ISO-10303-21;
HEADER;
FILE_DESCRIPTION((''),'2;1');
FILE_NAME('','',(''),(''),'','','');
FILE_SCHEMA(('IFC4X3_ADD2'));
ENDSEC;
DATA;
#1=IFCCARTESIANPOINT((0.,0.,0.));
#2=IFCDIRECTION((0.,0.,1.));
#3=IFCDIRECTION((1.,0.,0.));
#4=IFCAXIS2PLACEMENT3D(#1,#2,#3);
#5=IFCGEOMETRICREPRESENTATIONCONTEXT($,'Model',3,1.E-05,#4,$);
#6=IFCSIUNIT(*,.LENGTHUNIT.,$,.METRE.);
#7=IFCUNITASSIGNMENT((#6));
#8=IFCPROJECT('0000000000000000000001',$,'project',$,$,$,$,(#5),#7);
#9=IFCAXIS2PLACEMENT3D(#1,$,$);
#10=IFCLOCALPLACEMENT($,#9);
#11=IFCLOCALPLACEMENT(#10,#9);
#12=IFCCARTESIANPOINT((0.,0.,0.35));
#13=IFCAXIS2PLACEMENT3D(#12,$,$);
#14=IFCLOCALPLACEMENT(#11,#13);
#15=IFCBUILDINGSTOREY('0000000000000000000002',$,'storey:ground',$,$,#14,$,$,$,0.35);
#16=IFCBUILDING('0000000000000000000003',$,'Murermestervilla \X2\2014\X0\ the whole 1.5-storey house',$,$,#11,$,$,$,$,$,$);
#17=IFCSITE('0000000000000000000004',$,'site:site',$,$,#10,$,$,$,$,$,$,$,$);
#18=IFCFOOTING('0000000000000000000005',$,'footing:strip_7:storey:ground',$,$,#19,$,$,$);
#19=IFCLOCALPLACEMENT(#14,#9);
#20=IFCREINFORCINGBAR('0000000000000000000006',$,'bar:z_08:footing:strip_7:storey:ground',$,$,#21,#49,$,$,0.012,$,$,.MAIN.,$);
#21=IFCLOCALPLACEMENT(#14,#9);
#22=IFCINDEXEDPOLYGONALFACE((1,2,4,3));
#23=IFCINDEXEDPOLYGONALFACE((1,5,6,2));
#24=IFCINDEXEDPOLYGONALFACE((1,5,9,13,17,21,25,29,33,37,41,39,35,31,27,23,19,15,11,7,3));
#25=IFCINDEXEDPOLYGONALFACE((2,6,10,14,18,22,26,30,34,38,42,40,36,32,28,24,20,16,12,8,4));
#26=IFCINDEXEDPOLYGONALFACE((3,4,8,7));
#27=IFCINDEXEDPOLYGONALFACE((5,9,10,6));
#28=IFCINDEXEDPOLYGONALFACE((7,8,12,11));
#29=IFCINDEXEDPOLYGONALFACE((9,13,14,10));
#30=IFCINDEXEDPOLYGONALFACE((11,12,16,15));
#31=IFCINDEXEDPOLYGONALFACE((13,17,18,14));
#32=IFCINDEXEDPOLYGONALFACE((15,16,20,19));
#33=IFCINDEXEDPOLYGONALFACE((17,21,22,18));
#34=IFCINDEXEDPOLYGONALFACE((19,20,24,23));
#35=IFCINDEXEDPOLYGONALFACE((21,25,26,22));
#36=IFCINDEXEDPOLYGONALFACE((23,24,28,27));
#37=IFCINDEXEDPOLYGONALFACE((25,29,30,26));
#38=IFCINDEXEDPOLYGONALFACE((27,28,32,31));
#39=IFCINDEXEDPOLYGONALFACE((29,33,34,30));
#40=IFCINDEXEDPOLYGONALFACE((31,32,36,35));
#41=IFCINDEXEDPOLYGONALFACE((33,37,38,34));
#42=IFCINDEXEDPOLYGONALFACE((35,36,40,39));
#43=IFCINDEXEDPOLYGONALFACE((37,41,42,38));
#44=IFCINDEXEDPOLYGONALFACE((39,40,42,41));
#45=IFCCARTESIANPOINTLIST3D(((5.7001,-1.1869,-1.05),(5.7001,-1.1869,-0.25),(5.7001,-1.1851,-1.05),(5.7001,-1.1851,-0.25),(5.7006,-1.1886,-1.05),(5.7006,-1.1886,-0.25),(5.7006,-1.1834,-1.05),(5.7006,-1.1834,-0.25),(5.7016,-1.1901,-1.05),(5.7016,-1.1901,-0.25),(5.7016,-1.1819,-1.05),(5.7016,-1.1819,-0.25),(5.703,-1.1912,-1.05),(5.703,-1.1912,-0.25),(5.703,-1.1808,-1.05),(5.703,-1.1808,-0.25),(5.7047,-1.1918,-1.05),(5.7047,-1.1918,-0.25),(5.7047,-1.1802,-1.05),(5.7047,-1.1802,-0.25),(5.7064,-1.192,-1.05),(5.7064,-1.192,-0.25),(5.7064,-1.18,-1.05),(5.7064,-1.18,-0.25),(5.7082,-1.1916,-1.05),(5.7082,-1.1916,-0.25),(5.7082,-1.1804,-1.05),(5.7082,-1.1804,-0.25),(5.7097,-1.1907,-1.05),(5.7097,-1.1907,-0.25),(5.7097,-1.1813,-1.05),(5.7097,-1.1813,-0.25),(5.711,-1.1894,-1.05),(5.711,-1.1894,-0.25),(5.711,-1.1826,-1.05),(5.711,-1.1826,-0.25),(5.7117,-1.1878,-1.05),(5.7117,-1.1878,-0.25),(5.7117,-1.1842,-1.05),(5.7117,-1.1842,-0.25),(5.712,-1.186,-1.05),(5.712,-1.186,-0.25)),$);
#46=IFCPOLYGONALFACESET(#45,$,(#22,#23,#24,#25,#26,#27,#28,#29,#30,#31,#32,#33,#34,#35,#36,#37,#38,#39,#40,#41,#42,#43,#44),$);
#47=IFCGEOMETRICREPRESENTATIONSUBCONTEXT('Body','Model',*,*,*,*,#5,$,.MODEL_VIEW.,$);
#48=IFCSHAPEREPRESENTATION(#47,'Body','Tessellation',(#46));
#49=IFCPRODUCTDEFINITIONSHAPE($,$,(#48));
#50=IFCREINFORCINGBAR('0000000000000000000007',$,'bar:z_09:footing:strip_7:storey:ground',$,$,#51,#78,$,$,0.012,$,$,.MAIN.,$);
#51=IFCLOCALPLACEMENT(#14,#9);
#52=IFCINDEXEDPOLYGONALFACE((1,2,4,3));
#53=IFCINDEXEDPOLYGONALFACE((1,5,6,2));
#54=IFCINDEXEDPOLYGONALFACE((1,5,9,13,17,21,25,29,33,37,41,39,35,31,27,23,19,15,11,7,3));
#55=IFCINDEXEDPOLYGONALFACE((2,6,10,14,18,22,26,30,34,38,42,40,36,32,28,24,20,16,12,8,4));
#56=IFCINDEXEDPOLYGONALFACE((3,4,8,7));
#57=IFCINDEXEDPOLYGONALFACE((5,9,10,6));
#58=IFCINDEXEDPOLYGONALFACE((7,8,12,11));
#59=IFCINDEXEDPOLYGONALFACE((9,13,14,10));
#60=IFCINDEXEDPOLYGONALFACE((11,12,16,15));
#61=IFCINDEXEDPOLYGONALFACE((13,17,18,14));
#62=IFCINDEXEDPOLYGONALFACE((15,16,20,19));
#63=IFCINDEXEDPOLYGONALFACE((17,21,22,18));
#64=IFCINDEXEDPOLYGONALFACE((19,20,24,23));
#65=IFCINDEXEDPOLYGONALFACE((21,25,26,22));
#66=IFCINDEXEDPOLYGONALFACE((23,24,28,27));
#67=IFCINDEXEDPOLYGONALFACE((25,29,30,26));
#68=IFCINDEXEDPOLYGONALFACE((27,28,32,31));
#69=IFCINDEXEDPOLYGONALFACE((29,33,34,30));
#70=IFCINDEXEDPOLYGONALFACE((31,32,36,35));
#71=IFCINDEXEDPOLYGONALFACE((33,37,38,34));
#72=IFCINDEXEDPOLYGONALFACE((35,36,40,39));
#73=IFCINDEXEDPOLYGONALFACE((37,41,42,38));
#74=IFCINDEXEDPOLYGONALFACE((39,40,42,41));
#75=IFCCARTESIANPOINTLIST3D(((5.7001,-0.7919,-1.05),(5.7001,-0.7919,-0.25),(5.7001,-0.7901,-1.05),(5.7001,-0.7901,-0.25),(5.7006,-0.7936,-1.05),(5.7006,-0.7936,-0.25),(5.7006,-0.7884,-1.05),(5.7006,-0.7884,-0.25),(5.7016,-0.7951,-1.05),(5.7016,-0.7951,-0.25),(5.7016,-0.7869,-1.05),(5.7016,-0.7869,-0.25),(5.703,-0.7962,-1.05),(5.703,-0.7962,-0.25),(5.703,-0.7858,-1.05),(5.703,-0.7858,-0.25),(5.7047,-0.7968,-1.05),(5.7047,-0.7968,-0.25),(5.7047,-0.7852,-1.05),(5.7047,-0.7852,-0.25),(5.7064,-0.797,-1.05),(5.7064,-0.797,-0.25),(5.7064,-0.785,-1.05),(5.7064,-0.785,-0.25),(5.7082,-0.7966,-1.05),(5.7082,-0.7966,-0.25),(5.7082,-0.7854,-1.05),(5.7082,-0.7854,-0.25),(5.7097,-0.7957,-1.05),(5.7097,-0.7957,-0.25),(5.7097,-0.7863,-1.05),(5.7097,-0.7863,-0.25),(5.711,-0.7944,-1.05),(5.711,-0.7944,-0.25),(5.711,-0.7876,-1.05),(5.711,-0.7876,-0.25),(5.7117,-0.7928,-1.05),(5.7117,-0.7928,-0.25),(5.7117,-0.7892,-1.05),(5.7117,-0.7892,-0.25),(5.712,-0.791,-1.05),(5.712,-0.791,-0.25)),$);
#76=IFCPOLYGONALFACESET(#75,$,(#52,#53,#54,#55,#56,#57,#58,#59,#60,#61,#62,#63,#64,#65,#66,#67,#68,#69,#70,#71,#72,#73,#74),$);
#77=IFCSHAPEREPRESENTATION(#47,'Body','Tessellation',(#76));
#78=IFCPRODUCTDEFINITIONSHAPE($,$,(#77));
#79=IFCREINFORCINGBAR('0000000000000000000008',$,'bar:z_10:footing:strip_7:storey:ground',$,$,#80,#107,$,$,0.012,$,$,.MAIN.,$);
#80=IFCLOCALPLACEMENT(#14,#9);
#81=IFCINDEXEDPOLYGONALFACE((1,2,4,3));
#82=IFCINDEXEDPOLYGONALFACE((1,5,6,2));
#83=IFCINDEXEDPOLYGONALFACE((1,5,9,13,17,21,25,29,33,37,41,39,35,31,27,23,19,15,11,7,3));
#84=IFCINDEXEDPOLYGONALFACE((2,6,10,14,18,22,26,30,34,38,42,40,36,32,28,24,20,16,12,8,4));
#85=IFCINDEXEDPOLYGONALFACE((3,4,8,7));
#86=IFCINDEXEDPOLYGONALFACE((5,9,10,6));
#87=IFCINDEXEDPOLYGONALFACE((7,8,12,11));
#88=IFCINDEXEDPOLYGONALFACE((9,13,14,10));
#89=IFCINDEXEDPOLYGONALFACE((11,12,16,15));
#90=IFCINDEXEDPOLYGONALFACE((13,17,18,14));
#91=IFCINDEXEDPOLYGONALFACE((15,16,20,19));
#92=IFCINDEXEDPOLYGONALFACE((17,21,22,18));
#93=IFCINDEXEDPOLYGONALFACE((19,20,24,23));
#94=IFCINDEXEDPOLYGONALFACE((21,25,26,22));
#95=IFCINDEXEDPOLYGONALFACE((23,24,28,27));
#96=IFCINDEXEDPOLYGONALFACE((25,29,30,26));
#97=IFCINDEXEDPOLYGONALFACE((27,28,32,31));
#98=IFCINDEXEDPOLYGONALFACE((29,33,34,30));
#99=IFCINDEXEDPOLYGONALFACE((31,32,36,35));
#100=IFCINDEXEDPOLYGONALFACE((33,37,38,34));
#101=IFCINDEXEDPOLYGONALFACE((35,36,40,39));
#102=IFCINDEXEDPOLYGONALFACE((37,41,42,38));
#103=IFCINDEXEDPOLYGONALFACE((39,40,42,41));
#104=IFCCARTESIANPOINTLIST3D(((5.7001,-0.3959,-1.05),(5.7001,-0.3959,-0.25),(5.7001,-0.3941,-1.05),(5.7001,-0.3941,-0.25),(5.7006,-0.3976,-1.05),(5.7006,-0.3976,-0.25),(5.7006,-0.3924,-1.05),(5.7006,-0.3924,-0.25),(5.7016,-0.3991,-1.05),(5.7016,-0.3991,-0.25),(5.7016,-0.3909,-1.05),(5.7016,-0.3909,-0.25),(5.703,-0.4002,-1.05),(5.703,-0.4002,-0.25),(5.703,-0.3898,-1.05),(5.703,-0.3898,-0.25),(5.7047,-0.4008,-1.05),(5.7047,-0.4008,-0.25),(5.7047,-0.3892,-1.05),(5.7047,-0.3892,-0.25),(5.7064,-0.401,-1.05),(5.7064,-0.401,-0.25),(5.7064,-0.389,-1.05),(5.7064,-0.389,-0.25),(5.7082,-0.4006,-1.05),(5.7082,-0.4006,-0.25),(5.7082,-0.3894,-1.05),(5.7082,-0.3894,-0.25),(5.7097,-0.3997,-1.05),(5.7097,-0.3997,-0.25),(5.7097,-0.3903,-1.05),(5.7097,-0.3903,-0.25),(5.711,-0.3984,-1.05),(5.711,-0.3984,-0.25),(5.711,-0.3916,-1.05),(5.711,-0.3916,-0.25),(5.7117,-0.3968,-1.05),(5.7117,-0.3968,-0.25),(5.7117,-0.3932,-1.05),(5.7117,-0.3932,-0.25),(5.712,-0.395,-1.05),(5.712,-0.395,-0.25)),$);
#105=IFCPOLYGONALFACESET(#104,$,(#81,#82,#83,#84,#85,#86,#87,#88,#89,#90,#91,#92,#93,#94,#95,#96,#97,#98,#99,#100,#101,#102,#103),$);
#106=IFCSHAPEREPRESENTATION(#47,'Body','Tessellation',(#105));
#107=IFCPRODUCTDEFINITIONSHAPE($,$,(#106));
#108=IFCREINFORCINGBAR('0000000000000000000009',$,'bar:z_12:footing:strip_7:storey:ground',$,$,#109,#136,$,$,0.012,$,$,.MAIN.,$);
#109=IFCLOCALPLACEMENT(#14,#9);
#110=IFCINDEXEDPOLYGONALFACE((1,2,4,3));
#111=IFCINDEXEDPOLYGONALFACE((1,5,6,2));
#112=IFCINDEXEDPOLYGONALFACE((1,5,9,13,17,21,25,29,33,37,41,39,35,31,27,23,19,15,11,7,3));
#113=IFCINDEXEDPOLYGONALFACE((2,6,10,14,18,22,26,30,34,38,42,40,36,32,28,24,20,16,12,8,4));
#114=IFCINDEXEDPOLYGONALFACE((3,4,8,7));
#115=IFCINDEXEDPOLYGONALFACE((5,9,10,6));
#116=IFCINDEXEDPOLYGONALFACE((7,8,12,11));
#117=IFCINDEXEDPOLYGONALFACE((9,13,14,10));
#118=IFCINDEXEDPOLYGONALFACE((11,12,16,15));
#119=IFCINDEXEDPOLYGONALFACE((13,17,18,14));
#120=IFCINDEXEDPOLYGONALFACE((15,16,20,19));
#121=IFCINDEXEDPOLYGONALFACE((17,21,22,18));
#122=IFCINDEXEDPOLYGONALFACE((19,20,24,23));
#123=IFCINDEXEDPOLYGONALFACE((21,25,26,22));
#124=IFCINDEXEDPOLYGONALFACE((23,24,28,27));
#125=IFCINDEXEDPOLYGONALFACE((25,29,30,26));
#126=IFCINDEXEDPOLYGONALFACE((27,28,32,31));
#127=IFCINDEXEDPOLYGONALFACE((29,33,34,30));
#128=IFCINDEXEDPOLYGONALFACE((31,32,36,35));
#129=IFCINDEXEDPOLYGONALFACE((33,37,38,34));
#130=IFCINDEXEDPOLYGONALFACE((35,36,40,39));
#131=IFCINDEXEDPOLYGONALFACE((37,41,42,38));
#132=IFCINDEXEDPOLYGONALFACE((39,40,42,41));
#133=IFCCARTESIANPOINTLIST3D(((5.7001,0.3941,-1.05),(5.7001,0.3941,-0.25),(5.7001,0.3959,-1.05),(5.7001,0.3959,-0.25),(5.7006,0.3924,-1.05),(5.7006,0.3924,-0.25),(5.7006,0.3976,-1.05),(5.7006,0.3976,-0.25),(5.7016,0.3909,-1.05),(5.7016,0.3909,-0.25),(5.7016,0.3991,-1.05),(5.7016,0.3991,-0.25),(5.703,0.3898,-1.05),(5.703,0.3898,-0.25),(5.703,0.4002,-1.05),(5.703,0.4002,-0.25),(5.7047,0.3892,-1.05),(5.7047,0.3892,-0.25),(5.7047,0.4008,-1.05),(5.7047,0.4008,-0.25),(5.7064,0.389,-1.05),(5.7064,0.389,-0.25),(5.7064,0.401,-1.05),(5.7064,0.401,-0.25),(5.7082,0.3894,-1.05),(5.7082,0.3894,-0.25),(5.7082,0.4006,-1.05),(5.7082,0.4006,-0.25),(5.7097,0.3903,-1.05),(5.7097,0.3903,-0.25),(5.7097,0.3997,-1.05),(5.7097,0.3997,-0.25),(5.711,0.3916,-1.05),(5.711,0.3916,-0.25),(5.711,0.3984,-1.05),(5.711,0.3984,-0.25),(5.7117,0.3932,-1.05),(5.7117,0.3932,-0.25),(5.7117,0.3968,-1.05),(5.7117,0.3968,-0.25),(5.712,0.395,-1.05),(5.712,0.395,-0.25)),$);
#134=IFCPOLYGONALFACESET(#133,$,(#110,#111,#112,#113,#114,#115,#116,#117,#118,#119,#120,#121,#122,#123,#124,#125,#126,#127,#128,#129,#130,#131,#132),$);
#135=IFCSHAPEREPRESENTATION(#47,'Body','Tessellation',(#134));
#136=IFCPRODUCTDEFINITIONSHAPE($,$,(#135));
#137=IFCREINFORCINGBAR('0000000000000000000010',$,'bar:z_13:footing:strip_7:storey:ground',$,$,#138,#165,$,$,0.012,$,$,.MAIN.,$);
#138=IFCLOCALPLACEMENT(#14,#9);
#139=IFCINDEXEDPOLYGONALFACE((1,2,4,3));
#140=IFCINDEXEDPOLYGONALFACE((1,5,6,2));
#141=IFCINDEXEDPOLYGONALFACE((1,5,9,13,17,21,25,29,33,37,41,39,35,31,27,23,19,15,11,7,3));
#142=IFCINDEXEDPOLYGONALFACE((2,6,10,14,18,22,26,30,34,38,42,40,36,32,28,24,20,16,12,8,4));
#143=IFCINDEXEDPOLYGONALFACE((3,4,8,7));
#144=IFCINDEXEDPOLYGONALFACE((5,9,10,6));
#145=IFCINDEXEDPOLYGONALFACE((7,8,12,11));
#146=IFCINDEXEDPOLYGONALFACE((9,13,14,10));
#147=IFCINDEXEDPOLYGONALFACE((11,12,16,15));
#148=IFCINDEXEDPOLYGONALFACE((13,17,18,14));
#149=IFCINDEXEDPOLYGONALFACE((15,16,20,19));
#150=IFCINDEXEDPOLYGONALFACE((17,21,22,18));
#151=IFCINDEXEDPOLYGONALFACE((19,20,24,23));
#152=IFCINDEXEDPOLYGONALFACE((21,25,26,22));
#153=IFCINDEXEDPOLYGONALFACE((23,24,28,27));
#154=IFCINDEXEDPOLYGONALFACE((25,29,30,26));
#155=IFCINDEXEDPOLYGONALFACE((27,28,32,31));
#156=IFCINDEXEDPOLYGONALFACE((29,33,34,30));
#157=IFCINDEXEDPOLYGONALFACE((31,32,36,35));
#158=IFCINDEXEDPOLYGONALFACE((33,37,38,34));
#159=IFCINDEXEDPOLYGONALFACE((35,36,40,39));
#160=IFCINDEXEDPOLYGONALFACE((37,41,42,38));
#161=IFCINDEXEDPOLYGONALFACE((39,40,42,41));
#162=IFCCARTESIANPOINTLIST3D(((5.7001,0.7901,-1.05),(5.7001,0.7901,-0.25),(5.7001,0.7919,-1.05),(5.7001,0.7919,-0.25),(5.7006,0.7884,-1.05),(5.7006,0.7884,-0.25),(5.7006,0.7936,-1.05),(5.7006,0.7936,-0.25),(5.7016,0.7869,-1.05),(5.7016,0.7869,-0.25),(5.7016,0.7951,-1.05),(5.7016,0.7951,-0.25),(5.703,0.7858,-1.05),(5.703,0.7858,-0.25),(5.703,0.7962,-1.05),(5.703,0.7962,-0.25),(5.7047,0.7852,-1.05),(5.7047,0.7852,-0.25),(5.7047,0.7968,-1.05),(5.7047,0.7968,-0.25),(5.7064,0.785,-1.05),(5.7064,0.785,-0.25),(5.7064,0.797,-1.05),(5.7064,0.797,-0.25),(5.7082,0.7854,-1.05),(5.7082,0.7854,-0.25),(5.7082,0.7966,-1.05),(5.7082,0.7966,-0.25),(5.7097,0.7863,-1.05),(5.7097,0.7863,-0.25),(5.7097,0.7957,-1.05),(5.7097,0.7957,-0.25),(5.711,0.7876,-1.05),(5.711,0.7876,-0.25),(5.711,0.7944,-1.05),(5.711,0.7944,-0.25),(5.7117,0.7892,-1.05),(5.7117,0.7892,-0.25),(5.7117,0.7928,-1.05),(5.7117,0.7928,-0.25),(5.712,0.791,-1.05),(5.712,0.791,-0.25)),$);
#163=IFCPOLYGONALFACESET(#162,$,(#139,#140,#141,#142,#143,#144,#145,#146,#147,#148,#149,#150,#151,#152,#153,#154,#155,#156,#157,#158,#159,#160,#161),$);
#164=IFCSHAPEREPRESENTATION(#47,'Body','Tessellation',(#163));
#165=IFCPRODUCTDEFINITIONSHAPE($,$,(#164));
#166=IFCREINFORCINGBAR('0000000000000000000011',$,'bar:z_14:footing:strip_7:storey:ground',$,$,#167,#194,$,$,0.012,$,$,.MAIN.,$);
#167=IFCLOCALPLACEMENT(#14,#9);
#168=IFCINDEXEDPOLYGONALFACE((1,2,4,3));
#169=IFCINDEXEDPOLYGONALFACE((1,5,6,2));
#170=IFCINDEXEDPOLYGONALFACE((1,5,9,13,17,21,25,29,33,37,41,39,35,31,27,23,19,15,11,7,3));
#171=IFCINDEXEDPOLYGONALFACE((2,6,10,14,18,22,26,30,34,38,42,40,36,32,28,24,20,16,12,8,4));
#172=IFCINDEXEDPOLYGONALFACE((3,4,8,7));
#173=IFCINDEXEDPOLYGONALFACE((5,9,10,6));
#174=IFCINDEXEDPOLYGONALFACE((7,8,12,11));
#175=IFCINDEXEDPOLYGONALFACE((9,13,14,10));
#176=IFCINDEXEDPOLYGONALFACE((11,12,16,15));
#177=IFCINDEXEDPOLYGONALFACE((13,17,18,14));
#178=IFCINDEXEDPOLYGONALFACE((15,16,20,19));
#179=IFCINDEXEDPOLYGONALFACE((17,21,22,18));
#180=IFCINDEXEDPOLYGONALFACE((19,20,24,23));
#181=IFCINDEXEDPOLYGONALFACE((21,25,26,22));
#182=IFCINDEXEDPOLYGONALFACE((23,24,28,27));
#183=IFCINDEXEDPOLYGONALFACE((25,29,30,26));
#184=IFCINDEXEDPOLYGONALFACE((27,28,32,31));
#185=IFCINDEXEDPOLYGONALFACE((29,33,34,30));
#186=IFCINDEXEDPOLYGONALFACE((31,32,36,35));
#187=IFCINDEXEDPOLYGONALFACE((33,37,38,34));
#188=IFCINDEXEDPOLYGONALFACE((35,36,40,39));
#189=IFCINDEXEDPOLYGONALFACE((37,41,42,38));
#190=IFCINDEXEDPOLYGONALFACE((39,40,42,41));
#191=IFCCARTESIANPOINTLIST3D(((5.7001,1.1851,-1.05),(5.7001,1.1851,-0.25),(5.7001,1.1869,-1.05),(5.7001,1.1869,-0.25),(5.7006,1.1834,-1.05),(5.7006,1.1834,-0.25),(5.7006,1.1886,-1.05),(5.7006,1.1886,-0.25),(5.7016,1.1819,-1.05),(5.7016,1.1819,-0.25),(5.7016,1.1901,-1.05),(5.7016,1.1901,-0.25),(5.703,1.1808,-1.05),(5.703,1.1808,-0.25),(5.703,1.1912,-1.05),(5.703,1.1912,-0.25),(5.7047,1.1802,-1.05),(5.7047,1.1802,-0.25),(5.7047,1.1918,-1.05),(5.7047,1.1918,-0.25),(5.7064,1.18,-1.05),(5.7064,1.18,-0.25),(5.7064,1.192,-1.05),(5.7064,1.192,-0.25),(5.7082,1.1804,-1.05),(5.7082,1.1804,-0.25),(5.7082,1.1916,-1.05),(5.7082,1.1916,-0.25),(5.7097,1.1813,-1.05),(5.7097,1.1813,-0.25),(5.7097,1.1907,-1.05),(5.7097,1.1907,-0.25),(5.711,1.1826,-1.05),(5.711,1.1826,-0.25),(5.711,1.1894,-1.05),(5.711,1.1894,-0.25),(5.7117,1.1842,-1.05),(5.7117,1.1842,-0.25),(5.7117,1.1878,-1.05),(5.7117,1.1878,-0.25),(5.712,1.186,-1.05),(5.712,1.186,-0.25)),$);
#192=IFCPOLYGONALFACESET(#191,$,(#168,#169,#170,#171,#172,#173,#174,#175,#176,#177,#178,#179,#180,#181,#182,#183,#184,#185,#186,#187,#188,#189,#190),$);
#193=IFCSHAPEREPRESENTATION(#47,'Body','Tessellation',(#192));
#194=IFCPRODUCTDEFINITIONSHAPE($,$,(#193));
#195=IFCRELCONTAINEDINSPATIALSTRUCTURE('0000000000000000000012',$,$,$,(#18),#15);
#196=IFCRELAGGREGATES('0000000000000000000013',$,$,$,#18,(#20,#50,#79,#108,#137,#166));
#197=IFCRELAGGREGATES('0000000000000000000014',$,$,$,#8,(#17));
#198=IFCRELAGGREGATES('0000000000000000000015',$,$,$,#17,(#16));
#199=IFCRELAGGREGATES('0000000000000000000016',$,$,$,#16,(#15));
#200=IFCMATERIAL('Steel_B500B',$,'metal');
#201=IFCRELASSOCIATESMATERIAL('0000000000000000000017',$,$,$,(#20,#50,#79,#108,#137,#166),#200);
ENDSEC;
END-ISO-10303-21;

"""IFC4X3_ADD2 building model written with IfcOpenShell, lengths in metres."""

from ifc_helpers import new_model, entity, si_unit, frame, origin, origin_with_axes, place, context, subcontext, project, spatial, material, element, aggregate, save


model = new_model("IFC4X3_ADD2")

# Units and contexts
model_context = context("Model", 3, precision=1e-05, world=origin_with_axes())
body_context = subcontext(model_context, "Body", "Model", "MODEL_VIEW")
ifc_project = project(units=[si_unit("LENGTHUNIT", "METRE")], contexts=[model_context])

# Site, building, storey
placement_1 = place(None, origin())
site = spatial("IfcSite", under=ifc_project, at=placement_1, Name="site:site")
building_placement = place(placement_1, origin())
building = spatial("IfcBuilding", under=site, at=building_placement, Name="Murermestervilla — the whole 1.5-storey house")
storey_placement = place(building_placement, frame((0.0, 0.0, 0.35)))
storey = spatial("IfcBuildingStorey", under=building, at=storey_placement, Name="storey:ground", Elevation=0.35)

# Footing, reinforcing bars
placement_2 = place(storey_placement, frame((0.0, 0.0, -0.35)))
ifc_material = material(Name="Steel_B500B", Category="metal")
footing_1 = element("IfcFooting", 1, at=placement_2, inside=storey, Name="footing:strip_7:storey:ground")
reinforcing_bar_1 = element("IfcReinforcingBar", 2, at=placement_1, material=ifc_material, Name="bar:z_08:footing:strip_7:storey:ground", NominalDiameter=0.012, PredefinedType="MAIN", context=body_context, shape_type="AdvancedSweptSolid", body=[
    entity("IfcSweptDiskSolid", entity("IfcPolyline", [entity("IfcCartesianPoint", [5.706, -1.186, -0.7]), entity("IfcCartesianPoint", [5.706, -1.186, 0.1])]), 0.006),
])
reinforcing_bar_2 = element("IfcReinforcingBar", 3, at=placement_1, material=ifc_material, Name="bar:z_09:footing:strip_7:storey:ground", NominalDiameter=0.012, PredefinedType="MAIN", context=body_context, shape_type="AdvancedSweptSolid", body=[
    entity("IfcSweptDiskSolid", entity("IfcPolyline", [entity("IfcCartesianPoint", [5.706, -0.791, -0.7]), entity("IfcCartesianPoint", [5.706, -0.791, 0.1])]), 0.006),
])
reinforcing_bar_3 = element("IfcReinforcingBar", 4, at=placement_1, material=ifc_material, Name="bar:z_10:footing:strip_7:storey:ground", NominalDiameter=0.012, PredefinedType="MAIN", context=body_context, shape_type="AdvancedSweptSolid", body=[
    entity("IfcSweptDiskSolid", entity("IfcPolyline", [entity("IfcCartesianPoint", [5.706, -0.395, -0.7]), entity("IfcCartesianPoint", [5.706, -0.395, 0.1])]), 0.006),
])
reinforcing_bar_4 = element("IfcReinforcingBar", 5, at=placement_1, material=ifc_material, Name="bar:z_12:footing:strip_7:storey:ground", NominalDiameter=0.012, PredefinedType="MAIN", context=body_context, shape_type="AdvancedSweptSolid", body=[
    entity("IfcSweptDiskSolid", entity("IfcPolyline", [entity("IfcCartesianPoint", [5.706, 0.395, -0.7]), entity("IfcCartesianPoint", [5.706, 0.395, 0.1])]), 0.006),
])
reinforcing_bar_5 = element("IfcReinforcingBar", 6, at=placement_1, material=ifc_material, Name="bar:z_13:footing:strip_7:storey:ground", NominalDiameter=0.012, PredefinedType="MAIN", context=body_context, shape_type="AdvancedSweptSolid", body=[
    entity("IfcSweptDiskSolid", entity("IfcPolyline", [entity("IfcCartesianPoint", [5.706, 0.791, -0.7]), entity("IfcCartesianPoint", [5.706, 0.791, 0.1])]), 0.006),
])
reinforcing_bar_6 = element("IfcReinforcingBar", 7, at=placement_1, material=ifc_material, Name="bar:z_14:footing:strip_7:storey:ground", NominalDiameter=0.012, PredefinedType="MAIN", context=body_context, shape_type="AdvancedSweptSolid", body=[
    entity("IfcSweptDiskSolid", entity("IfcPolyline", [entity("IfcCartesianPoint", [5.706, 1.186, -0.7]), entity("IfcCartesianPoint", [5.706, 1.186, 0.1])]), 0.006),
])
aggregate(footing_1, [reinforcing_bar_1, reinforcing_bar_2, reinforcing_bar_3, reinforcing_bar_4, reinforcing_bar_5, reinforcing_bar_6])

save(model, "model.ifc")
